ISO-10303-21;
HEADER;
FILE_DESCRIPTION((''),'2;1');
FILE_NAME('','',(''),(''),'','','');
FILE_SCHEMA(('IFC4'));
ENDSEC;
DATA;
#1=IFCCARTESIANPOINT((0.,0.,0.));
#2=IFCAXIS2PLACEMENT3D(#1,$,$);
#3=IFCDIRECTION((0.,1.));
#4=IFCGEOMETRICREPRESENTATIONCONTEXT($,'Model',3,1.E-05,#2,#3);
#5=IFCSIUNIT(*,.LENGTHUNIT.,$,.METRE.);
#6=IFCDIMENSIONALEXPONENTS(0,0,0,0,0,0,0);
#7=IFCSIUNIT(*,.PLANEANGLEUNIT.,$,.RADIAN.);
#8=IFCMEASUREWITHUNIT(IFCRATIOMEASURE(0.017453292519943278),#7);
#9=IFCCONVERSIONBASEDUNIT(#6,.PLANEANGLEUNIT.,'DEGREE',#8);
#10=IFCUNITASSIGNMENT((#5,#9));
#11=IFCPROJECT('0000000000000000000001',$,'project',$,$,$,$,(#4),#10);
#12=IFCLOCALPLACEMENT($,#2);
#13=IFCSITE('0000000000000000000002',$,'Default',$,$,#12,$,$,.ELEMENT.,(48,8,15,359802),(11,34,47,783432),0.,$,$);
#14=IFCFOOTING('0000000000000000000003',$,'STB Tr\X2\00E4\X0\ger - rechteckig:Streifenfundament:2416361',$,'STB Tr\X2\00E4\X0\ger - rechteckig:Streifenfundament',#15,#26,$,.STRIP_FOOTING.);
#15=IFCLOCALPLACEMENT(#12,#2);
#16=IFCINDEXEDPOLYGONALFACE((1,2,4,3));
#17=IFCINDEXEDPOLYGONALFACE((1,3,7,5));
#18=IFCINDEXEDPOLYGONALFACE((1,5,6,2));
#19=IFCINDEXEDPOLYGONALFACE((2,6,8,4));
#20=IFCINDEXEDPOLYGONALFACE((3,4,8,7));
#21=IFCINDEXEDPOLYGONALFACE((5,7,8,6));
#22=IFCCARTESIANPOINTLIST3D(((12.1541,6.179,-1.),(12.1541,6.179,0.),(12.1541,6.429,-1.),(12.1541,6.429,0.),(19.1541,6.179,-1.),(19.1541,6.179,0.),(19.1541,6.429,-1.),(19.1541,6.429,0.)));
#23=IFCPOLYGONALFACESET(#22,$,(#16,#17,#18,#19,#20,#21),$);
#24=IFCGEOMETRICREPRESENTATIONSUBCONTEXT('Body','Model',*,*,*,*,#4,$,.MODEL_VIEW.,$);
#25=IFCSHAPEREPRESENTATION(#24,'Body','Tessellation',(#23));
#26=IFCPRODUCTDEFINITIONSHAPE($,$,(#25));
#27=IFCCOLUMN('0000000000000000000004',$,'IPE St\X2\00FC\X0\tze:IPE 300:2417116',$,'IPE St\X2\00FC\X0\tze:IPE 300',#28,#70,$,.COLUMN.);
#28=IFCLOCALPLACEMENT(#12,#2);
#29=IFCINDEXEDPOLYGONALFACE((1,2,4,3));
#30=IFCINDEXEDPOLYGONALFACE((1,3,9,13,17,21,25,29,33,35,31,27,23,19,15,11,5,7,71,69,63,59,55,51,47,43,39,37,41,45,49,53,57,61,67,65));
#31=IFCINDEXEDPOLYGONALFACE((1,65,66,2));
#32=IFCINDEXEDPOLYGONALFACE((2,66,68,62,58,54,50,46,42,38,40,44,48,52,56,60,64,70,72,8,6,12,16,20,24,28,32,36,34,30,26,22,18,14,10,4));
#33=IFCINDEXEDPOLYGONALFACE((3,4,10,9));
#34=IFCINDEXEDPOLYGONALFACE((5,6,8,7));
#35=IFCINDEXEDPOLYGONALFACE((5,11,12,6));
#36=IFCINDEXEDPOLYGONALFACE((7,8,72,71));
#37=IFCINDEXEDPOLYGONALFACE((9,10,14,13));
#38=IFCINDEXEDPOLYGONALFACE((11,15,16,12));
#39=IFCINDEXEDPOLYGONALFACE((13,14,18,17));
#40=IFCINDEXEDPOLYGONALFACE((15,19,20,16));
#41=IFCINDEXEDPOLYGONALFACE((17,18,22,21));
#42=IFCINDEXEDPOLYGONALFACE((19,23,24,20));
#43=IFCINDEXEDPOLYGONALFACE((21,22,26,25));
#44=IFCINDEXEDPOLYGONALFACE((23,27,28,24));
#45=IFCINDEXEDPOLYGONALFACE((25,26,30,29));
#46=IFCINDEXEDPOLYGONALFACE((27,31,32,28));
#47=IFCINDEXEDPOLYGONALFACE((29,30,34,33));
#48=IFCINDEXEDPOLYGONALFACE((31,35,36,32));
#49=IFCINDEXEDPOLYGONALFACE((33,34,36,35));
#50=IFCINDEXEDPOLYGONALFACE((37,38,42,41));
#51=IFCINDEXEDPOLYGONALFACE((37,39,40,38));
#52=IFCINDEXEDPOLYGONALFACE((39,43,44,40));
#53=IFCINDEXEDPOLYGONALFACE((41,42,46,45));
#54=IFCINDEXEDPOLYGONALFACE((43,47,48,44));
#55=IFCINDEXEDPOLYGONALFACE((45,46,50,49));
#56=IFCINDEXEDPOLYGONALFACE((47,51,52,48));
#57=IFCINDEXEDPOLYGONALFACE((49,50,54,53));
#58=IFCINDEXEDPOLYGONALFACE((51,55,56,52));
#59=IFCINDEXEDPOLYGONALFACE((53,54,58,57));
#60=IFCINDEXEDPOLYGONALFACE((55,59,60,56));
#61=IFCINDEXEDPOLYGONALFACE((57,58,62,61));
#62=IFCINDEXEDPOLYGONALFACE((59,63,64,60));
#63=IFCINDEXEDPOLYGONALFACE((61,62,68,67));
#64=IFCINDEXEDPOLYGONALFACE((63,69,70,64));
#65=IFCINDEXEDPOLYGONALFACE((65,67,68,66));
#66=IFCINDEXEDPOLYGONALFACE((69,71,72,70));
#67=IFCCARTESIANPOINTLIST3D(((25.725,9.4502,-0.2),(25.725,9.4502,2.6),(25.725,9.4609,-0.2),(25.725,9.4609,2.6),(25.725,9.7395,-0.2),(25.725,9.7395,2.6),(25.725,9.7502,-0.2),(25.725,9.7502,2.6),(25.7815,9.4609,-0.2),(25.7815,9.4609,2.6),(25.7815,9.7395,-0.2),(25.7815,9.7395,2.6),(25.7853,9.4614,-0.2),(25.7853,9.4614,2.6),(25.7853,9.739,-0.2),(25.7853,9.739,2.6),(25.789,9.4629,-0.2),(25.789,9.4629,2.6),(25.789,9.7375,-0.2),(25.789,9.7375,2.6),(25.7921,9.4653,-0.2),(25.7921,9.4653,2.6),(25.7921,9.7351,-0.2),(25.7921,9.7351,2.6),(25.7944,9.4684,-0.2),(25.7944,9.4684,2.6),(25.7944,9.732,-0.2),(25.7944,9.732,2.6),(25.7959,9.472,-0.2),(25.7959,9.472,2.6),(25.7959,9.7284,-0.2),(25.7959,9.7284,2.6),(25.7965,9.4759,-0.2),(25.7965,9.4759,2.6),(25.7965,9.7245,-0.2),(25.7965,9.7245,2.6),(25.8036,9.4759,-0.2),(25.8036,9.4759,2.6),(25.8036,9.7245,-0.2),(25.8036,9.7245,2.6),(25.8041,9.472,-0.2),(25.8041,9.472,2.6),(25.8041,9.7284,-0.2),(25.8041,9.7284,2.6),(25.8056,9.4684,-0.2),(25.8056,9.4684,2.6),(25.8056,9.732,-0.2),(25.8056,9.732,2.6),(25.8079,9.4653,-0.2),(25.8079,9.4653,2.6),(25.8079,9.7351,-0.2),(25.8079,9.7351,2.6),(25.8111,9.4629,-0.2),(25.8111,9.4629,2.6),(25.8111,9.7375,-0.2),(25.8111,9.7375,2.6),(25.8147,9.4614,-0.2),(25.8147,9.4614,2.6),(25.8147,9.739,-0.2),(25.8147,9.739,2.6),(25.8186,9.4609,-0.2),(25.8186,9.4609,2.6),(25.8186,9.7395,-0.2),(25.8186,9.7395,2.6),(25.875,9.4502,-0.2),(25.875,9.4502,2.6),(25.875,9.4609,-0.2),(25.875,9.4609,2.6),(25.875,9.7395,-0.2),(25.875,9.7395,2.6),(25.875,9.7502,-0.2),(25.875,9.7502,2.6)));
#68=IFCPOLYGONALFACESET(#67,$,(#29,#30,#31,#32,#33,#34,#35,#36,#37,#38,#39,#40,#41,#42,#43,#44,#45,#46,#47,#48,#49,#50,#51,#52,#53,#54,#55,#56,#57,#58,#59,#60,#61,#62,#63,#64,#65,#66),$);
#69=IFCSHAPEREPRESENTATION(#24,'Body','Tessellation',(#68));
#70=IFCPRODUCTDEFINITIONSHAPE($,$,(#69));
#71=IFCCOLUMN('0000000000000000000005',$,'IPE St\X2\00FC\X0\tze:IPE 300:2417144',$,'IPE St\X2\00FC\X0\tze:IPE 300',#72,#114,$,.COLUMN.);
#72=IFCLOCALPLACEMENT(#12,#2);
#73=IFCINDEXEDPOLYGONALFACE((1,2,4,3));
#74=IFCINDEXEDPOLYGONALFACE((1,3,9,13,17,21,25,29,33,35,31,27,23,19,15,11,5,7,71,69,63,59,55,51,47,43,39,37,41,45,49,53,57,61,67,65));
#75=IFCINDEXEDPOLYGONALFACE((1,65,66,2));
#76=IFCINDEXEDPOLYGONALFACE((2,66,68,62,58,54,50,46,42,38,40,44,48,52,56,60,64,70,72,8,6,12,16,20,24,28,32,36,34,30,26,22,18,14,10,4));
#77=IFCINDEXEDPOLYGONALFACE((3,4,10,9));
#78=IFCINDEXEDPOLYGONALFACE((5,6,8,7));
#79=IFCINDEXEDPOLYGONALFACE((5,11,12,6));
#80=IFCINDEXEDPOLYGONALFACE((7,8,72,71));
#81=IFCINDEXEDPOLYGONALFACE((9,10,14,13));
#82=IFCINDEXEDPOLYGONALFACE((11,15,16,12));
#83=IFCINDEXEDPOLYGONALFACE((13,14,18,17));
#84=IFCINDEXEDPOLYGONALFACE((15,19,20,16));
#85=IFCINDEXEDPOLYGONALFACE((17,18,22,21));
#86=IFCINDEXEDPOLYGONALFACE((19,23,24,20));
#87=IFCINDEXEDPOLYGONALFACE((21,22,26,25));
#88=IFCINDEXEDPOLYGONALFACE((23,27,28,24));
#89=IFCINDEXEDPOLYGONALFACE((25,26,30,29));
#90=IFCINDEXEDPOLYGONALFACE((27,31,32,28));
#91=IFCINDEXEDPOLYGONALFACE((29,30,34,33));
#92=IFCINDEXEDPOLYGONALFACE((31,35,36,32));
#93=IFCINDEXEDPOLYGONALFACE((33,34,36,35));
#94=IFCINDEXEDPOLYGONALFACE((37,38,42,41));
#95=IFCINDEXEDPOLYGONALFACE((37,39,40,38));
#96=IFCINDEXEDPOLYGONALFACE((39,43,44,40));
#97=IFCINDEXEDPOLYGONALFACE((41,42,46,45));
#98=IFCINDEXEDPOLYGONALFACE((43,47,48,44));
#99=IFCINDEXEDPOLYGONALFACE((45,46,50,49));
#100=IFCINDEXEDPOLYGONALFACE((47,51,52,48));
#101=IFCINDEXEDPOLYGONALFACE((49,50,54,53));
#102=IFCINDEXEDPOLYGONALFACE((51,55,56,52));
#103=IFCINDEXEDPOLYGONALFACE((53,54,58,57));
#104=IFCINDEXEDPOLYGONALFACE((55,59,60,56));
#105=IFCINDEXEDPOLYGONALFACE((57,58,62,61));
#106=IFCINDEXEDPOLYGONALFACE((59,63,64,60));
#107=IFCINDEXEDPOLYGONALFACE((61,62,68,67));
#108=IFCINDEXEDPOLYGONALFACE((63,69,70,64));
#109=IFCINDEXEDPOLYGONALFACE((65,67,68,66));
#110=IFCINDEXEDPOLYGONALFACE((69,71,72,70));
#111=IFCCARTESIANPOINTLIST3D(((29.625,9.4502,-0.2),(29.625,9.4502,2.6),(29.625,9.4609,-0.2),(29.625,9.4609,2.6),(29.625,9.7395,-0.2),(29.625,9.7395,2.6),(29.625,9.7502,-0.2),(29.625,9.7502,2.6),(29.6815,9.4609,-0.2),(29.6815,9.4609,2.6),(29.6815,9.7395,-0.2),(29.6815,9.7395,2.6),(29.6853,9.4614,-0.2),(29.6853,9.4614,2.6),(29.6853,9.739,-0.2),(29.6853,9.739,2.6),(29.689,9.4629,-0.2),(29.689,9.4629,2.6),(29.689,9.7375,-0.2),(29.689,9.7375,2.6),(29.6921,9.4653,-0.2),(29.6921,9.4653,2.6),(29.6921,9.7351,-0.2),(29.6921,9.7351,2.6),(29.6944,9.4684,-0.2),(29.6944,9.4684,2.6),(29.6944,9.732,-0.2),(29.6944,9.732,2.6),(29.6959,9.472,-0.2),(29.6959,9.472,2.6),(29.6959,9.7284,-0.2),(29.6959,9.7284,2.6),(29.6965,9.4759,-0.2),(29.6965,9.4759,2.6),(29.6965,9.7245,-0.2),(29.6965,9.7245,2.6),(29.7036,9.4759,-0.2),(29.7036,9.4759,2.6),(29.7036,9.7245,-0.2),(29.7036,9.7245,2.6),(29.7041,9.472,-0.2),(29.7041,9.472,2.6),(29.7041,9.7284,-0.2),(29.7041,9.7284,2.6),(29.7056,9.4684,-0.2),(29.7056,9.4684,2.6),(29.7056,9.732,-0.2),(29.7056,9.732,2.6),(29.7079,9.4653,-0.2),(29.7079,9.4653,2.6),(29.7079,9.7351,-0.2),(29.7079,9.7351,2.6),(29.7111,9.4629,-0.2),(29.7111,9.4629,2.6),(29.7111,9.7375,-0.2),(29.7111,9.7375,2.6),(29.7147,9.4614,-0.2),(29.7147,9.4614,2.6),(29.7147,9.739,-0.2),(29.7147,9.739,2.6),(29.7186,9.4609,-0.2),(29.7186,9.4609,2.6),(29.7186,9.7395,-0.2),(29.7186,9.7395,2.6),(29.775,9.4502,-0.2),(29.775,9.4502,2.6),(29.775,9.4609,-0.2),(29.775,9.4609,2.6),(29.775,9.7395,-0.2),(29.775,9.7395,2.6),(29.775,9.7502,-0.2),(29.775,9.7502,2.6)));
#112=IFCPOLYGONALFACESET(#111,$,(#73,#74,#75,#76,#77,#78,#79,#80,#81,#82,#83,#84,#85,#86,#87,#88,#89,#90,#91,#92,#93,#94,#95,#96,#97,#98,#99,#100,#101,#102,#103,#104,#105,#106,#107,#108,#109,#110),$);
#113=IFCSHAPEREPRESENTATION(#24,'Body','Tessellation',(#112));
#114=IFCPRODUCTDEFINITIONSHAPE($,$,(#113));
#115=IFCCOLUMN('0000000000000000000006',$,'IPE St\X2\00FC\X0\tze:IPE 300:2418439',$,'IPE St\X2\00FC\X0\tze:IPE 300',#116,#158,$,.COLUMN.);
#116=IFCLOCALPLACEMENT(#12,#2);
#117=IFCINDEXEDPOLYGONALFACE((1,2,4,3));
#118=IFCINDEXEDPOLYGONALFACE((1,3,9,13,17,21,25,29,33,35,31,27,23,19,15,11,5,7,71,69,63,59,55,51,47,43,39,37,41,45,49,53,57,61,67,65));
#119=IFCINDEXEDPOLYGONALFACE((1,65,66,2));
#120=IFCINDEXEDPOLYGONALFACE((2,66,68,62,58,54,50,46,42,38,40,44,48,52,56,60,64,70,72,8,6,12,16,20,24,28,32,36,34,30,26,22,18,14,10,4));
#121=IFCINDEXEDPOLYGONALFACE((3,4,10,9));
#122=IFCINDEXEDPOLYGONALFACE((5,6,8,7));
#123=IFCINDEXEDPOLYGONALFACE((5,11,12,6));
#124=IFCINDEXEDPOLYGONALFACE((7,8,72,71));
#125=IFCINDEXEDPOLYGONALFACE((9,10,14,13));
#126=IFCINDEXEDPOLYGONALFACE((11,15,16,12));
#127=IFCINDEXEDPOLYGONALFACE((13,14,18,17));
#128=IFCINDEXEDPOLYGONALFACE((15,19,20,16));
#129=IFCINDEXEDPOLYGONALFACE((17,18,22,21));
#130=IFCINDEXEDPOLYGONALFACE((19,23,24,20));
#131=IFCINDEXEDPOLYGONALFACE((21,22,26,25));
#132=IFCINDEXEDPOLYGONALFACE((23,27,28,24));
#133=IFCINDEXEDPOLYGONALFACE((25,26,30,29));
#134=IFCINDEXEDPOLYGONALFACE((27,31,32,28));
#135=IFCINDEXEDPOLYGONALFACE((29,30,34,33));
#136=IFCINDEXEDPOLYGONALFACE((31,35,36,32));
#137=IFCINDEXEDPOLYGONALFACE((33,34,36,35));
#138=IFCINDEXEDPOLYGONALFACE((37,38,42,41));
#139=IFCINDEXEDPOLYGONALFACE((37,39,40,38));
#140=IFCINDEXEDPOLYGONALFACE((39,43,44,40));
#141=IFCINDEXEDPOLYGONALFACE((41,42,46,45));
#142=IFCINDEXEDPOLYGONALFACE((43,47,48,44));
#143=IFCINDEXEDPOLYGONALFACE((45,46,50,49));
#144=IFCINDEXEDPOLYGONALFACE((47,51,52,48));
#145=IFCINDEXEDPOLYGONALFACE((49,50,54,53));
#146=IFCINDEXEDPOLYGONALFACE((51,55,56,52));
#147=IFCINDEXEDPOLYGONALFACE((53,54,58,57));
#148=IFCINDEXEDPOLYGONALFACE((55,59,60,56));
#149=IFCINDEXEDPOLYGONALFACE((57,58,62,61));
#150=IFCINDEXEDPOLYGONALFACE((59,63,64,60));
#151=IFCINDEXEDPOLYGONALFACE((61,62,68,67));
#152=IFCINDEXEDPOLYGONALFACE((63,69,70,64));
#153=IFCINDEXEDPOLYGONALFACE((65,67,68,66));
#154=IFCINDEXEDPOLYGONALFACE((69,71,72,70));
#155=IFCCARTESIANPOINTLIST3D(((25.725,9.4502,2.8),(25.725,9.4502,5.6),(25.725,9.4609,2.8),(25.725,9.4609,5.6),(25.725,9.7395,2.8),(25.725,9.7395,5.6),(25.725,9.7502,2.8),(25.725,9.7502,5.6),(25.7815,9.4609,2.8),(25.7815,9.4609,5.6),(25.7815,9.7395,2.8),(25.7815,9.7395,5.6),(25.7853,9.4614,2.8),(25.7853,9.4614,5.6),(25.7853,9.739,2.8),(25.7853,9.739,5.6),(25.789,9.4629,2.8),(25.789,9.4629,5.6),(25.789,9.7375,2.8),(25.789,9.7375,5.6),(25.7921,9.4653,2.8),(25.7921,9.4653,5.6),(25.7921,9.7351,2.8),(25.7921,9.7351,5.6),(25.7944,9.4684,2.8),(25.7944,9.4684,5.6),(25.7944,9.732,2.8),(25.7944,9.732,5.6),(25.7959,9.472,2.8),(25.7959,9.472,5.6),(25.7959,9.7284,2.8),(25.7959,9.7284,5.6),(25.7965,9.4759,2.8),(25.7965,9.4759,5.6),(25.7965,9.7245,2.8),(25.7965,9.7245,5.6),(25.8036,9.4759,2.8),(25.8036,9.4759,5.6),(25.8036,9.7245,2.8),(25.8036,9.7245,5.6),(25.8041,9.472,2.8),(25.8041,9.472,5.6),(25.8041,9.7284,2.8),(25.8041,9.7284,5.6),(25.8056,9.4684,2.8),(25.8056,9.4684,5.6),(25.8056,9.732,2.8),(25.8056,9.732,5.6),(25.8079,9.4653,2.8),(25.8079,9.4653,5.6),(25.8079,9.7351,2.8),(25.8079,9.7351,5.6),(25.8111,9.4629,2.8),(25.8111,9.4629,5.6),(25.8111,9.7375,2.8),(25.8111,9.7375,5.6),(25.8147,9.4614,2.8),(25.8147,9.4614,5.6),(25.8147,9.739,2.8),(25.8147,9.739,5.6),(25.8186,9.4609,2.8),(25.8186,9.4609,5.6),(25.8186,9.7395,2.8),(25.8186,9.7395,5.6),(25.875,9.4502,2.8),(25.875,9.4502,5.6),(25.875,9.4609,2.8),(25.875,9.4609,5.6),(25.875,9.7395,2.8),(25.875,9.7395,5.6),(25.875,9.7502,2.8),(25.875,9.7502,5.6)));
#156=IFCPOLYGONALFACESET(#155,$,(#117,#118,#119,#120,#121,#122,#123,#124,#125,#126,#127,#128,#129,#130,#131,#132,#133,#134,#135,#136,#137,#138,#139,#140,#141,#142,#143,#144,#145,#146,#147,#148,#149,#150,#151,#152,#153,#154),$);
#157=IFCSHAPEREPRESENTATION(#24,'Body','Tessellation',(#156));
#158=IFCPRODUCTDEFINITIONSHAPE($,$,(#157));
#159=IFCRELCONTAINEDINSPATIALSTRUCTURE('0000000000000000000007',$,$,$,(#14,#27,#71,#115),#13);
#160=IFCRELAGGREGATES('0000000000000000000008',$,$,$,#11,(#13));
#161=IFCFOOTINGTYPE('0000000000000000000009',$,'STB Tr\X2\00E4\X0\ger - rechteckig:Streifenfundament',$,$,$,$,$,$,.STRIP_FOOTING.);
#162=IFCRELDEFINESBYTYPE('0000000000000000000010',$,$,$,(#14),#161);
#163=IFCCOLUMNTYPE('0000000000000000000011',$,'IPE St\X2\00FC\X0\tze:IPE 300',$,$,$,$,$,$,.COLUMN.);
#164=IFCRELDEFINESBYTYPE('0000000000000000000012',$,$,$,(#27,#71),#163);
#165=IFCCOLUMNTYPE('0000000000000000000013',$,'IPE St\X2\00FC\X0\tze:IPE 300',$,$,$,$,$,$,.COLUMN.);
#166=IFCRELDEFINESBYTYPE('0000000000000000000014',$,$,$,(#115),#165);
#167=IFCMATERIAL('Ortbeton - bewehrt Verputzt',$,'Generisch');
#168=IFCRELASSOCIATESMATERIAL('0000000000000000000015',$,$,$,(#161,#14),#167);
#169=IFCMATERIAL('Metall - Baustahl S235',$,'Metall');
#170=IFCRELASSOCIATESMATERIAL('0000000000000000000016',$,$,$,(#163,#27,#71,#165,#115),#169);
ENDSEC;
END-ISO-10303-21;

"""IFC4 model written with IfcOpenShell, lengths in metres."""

from ifc_helpers import new_model, entity, si_unit, converted_unit, direction, frame, origin, place, context, subcontext, project, spatial, line, arc, indexed_curve, outline, extrude, source, transform, mapped, material, type_object, type_shapes, element, save


model = new_model("IFC4")

# Units and contexts
model_context = context("Model", 3, precision=1e-05, world=origin(), true_north=direction((0.0, 1.0)))
body_context = subcontext(model_context, "Body", "Model", "MODEL_VIEW")
ifc_project = project(units=[si_unit("LENGTHUNIT", "METRE"), converted_unit("PLANEANGLEUNIT", "DEGREE", entity("IfcRatioMeasure", 0.017453292519943278), si_unit("PLANEANGLEUNIT", "RADIAN"), dimensions=[0, 0, 0, 0, 0, 0, 0])], contexts=[model_context])

# Site
site_placement = place(None, origin())
site = spatial("IfcSite", under=ifc_project, at=site_placement, Name="Default", CompositionType="ELEMENT", RefLatitude=(48, 8, 15, 359802), RefLongitude=(11, 34, 47, 783432), RefElevation=0.0)

# Footing
ifc_material_1 = material(Name="Ortbeton - bewehrt Verputzt", Category="Generisch")
footing_type = type_object("IfcFootingType", Name="STB Träger - rechteckig:Streifenfundament", PredefinedType="STRIP_FOOTING", material=ifc_material_1)
shared_shape_1 = source(origin(), body_context, "Body", "SweptSolid", [
    extrude(outline(indexed_curve([(-3.5, -0.125), (3.5, -0.125), (3.5, 0.125), (-3.5, 0.125), (-3.5, -0.125)], self_intersect=False)), frame((0.0, 0.0, -0.5), z_axis=(0.0, 0.0, 1.0), x_axis=(-1.0, 0.0, 0.0)), (0.0, 0.0, 1.0), 1.0),
])
type_shapes(footing_type, [shared_shape_1])
footing_placement = place(site_placement, frame((15.6541, 6.304, -0.5)))
element("IfcFooting", 1, at=footing_placement, inside=site, type_object=footing_type, material=ifc_material_1, Name="STB Träger - rechteckig:Streifenfundament:2416361", ObjectType="STB Träger - rechteckig:Streifenfundament", PredefinedType="STRIP_FOOTING", context=body_context, shape_type="MappedRepresentation", body=[
    mapped(shared_shape_1, transform((0.0, 0.0, 0.0), scale=1.0)),
])

# Columns
ifc_material_2 = material(Name="Metall - Baustahl S235", Category="Metall")
column_type_1 = type_object("IfcColumnType", Name="IPE Stütze:IPE 300", PredefinedType="COLUMN", material=ifc_material_2)
shared_shape_2 = source(origin(), body_context, "Body", "SweptSolid", [
    extrude(outline(indexed_curve([(0.1393, -0.075), (0.15, -0.075), (0.15, 0.075), (0.1393, 0.075), (0.1393, 0.0186), (0.1349, 0.0079), (0.1243, 0.0036), (-0.1243, 0.0036), (-0.1349, 0.0079), (-0.1393, 0.0186), (-0.1393, 0.075), (-0.15, 0.075), (-0.15, -0.075), (-0.1393, -0.075), (-0.1393, -0.0186), (-0.1349, -0.0079), (-0.1243, -0.0035), (0.1243, -0.0036), (0.1349, -0.0079), (0.1393, -0.0185)], segments=[line(1, 2, 3, 4, 5), arc(5, 6, 7), line(7, 8), arc(8, 9, 10), line(10, 11, 12, 13, 14, 15), arc(15, 16, 17), line(17, 18), arc(18, 19, 20), line(20, 1)], self_intersect=False)), frame((0.0, 0.0, -0.2), z_axis=(0.0, 0.0, 1.0), x_axis=(0.0, -1.0, 0.0)), (0.0, 0.0, 1.0), 2.8),
])
type_shapes(column_type_1, [shared_shape_2])
for number, where, name in (
    (2, (25.8, 9.6002, 0.0), "IPE Stütze:IPE 300:2417116"),
    (3, (29.7, 9.6002, 0.0), "IPE Stütze:IPE 300:2417144"),
):
    element("IfcColumn", number, at=place(site_placement, frame(where)), inside=site, type_object=column_type_1, material=ifc_material_2, Name=name, ObjectType="IPE Stütze:IPE 300", PredefinedType="COLUMN", context=body_context, shape_type="MappedRepresentation", body=[
        mapped(shared_shape_2, transform((0.0, 0.0, 0.0), scale=1.0)),
    ])
column_type_2 = type_object("IfcColumnType", Name="IPE Stütze:IPE 300", PredefinedType="COLUMN", material=ifc_material_2)
shared_shape_3 = source(origin(), body_context, "Body", "SweptSolid", [
    extrude(outline(indexed_curve([(0.1393, -0.075), (0.15, -0.075), (0.15, 0.075), (0.1393, 0.075), (0.1393, 0.0186), (0.1349, 0.0079), (0.1243, 0.0036), (-0.1243, 0.0036), (-0.1349, 0.0079), (-0.1393, 0.0186), (-0.1393, 0.075), (-0.15, 0.075), (-0.15, -0.075), (-0.1393, -0.075), (-0.1393, -0.0186), (-0.1349, -0.0079), (-0.1243, -0.0035), (0.1243, -0.0036), (0.1349, -0.0079), (0.1393, -0.0185)], segments=[line(1, 2, 3, 4, 5), arc(5, 6, 7), line(7, 8), arc(8, 9, 10), line(10, 11, 12, 13, 14, 15), arc(15, 16, 17), line(17, 18), arc(18, 19, 20), line(20, 1)], self_intersect=False)), frame((0.0, 0.0, 2.8), z_axis=(0.0, 0.0, 1.0), x_axis=(0.0, -1.0, 0.0)), (0.0, 0.0, 1.0), 2.8),
])
type_shapes(column_type_2, [shared_shape_3])
for number, where, name in (
    (4, (25.8, 9.6002, 0.0), "IPE Stütze:IPE 300:2418439"),
):
    element("IfcColumn", number, at=place(site_placement, frame(where)), inside=site, type_object=column_type_2, material=ifc_material_2, Name=name, ObjectType="IPE Stütze:IPE 300", PredefinedType="COLUMN", context=body_context, shape_type="MappedRepresentation", body=[
        mapped(shared_shape_3, transform((0.0, 0.0, 0.0), scale=1.0)),
    ])

save(model, "model.ifc")
